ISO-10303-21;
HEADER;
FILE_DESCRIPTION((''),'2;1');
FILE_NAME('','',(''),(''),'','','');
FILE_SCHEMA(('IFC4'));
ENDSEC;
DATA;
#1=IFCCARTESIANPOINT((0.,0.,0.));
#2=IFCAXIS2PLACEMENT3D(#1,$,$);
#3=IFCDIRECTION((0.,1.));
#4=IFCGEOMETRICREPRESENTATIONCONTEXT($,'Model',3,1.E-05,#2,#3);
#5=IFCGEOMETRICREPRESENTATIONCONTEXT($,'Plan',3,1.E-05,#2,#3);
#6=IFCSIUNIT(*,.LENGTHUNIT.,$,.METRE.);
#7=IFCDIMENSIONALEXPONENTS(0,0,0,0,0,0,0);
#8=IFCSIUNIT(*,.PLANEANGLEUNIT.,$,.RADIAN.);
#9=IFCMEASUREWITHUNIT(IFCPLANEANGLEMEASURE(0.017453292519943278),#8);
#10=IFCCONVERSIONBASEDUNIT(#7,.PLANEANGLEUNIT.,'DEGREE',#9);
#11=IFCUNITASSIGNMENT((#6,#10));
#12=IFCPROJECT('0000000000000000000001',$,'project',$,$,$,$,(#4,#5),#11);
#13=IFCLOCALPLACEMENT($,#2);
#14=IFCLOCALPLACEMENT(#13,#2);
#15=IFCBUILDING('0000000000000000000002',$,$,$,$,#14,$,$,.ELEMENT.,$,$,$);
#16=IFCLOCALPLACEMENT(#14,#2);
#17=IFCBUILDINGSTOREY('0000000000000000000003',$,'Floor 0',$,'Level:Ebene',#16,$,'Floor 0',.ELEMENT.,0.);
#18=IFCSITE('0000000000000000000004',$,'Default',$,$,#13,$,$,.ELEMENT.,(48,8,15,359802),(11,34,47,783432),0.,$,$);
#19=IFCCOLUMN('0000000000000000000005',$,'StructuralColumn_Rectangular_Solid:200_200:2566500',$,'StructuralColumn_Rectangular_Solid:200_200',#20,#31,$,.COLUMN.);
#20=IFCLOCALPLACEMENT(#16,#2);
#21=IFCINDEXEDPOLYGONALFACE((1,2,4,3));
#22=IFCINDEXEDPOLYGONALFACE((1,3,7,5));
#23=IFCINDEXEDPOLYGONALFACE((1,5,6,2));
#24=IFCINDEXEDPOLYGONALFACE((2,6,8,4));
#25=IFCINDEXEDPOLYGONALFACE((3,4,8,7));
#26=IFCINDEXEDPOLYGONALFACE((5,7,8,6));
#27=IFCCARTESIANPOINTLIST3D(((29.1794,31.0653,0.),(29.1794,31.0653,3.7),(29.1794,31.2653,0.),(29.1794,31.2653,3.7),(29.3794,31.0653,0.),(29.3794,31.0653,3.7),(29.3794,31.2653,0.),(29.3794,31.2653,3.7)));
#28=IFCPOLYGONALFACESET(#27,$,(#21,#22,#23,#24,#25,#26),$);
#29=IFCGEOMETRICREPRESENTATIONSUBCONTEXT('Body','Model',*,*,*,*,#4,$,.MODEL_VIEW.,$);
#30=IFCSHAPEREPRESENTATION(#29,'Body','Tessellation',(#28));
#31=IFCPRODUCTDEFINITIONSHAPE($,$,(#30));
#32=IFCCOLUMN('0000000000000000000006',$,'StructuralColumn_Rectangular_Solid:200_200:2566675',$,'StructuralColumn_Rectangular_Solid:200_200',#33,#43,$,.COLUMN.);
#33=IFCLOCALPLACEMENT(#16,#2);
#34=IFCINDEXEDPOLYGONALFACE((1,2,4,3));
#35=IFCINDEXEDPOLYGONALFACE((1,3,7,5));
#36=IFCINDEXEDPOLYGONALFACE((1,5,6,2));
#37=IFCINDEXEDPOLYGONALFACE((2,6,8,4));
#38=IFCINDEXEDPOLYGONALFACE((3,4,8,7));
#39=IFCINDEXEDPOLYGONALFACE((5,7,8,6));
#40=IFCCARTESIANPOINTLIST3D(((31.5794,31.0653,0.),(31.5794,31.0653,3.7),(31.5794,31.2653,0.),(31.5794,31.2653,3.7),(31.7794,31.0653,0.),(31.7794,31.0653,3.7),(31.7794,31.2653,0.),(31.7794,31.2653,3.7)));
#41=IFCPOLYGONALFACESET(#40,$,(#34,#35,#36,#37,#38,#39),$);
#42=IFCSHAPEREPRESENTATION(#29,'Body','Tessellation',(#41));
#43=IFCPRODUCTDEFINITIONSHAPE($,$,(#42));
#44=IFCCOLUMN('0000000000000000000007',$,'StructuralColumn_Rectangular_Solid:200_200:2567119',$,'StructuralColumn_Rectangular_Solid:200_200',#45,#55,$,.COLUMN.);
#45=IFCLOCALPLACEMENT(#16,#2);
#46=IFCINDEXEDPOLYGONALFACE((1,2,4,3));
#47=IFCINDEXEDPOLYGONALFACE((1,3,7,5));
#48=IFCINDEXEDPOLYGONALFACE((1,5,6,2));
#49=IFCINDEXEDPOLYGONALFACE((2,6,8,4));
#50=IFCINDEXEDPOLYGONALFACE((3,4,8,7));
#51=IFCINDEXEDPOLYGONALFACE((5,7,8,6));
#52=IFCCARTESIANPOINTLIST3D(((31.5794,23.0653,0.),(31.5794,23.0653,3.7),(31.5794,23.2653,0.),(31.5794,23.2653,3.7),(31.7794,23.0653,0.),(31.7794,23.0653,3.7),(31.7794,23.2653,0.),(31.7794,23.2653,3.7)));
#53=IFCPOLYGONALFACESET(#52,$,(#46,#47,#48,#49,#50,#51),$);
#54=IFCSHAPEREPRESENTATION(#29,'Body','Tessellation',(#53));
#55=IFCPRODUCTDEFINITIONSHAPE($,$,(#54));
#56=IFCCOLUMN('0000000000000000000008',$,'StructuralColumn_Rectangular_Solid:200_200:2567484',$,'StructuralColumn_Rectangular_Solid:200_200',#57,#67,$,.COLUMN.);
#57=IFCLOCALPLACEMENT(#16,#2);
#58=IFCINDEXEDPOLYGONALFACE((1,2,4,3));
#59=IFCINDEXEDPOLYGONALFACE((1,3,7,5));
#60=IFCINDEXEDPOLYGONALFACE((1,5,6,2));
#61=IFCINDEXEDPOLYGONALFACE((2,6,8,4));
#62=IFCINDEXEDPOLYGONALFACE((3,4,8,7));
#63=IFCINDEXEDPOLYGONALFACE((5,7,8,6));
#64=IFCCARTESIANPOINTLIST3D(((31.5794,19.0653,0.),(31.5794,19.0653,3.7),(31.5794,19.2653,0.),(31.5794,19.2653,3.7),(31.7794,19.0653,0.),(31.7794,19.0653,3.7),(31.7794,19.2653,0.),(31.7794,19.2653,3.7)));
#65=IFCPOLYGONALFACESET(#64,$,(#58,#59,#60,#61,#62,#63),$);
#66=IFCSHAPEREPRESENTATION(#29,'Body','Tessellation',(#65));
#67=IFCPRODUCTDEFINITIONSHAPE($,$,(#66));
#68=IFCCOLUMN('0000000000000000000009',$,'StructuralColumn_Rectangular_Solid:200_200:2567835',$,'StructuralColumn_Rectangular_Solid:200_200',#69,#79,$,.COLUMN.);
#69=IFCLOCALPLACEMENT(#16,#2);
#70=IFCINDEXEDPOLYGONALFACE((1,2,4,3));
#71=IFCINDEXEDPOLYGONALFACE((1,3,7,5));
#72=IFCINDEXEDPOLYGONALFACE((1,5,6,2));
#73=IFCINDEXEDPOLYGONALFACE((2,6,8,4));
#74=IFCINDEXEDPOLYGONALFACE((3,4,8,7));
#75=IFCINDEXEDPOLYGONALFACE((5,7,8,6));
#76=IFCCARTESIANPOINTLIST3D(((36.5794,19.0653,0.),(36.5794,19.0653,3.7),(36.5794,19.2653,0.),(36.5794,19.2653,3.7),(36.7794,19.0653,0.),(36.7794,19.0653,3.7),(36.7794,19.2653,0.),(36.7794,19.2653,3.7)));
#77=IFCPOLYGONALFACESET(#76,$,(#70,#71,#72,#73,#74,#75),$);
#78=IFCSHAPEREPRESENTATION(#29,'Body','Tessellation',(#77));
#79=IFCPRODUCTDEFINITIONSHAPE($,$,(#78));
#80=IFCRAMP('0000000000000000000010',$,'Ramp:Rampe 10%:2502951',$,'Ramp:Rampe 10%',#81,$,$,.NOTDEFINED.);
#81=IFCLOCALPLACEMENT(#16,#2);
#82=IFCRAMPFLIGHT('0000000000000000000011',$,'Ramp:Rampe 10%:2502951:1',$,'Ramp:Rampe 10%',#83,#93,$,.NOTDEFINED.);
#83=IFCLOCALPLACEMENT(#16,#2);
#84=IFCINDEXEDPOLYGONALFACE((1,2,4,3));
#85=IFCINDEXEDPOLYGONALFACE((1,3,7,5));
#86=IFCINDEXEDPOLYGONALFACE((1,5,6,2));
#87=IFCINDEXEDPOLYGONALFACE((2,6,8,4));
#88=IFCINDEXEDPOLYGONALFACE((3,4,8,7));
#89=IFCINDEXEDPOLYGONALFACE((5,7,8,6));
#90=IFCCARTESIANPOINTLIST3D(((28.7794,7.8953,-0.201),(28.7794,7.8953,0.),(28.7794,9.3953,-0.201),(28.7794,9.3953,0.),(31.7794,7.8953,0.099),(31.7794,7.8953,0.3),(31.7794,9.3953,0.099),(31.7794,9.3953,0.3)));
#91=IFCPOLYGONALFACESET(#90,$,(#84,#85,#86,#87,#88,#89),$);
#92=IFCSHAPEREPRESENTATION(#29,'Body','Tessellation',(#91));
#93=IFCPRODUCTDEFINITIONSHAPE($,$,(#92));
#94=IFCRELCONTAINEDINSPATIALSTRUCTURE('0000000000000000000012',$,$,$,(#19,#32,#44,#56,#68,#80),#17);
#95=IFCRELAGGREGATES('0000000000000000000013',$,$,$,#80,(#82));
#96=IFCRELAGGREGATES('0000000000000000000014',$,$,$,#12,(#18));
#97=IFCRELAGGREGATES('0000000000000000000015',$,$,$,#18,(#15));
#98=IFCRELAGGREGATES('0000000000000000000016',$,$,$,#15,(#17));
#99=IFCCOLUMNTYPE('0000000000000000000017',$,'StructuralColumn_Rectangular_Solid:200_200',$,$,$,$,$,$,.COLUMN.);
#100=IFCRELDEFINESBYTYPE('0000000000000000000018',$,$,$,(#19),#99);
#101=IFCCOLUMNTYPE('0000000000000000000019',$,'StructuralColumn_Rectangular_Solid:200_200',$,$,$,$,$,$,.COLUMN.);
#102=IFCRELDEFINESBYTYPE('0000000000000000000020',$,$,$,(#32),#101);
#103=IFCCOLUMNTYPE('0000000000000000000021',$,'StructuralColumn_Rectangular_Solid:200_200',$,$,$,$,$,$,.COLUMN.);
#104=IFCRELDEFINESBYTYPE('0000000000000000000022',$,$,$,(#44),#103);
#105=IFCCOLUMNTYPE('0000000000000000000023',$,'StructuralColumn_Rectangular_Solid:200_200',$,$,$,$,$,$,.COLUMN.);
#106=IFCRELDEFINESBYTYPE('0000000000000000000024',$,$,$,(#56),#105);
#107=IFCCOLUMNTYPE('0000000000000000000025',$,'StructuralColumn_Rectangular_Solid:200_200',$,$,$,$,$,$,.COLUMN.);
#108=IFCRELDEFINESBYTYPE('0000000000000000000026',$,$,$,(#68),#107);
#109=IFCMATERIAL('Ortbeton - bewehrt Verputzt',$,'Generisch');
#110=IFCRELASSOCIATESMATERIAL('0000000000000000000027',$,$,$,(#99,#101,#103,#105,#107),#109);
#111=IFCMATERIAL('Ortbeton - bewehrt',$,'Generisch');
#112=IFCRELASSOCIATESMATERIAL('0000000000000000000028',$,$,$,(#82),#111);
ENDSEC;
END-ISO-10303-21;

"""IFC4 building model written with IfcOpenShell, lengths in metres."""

from ifc_helpers import new_model, entity, si_unit, converted_unit, direction, frame, frame_2d, origin, origin_2d_with_axis, place, context, subcontext, project, spatial, polyline, rectangle, outline, extrude, source, transform, mapped, material, material_profile, profile_set, type_object, type_shapes, element, aggregate, save


model = new_model("IFC4")

# Units and contexts
model_context = context("Model", 3, precision=1e-05, world=origin(), true_north=direction((0.0, 1.0)))
plan_context = context("Plan", 3, precision=1e-05, world=origin(), true_north=direction((0.0, 1.0)))
body_context = subcontext(model_context, "Body", "Model", "MODEL_VIEW")
ifc_project = project(units=[si_unit("LENGTHUNIT", "METRE"), converted_unit("PLANEANGLEUNIT", "DEGREE", entity("IfcPlaneAngleMeasure", 0.017453292519943278), si_unit("PLANEANGLEUNIT", "RADIAN"), dimensions=[0, 0, 0, 0, 0, 0, 0])], contexts=[model_context, plan_context])

# Site, building, storey
site_placement = place(None, origin())
site = spatial("IfcSite", under=ifc_project, at=site_placement, Name="Default", CompositionType="ELEMENT", RefLatitude=(48, 8, 15, 359802), RefLongitude=(11, 34, 47, 783432), RefElevation=0.0)
building_placement = place(site_placement, origin())
building = spatial("IfcBuilding", under=site, at=building_placement, CompositionType="ELEMENT")
storey_placement = place(building_placement, origin())
storey = spatial("IfcBuildingStorey", under=building, at=storey_placement, Name="Floor 0", ObjectType="Level:Ebene", LongName="Floor 0", CompositionType="ELEMENT", Elevation=0.0)

# Columns
ifc_material_1 = material(Name="Ortbeton - bewehrt Verputzt", Category="Generisch")
ifc_material_profile = material_profile(ifc_material_1, rectangle(XDim=0.2, YDim=0.2, at=frame_2d((0.0, 0.0), x_axis=(1.0, 0.0))), Name="200_200")
ifc_profile_set = profile_set([ifc_material_profile], Name="200_200")
column_type_1 = type_object("IfcColumnType", Name="StructuralColumn_Rectangular_Solid:200_200", PredefinedType="COLUMN", material=ifc_profile_set)
shared_shape_1 = source(origin(), body_context, "Body", "SweptSolid", [
    extrude(rectangle(XDim=0.2, YDim=0.2, at=origin_2d_with_axis()), frame((29.2794, 31.1653, 0.0), z_axis=(0.0, 0.0, 1.0), x_axis=(-1.0, 0.0, 0.0)), (0.0, 0.0, 1.0), 3.7),
])
type_shapes(column_type_1, [shared_shape_1])
column_1_placement = place(storey_placement, origin())
element("IfcColumn", 1, at=column_1_placement, inside=storey, type_object=column_type_1, Name="StructuralColumn_Rectangular_Solid:200_200:2566500", ObjectType="StructuralColumn_Rectangular_Solid:200_200", PredefinedType="COLUMN", context=body_context, shape_type="MappedRepresentation", body=[
    mapped(shared_shape_1, transform((0.0, 0.0, 0.0), scale=1.0)),
])
column_type_2 = type_object("IfcColumnType", Name="StructuralColumn_Rectangular_Solid:200_200", PredefinedType="COLUMN", material=ifc_profile_set)
shared_shape_2 = source(origin(), body_context, "Body", "SweptSolid", [
    extrude(rectangle(XDim=0.2, YDim=0.2, at=origin_2d_with_axis()), frame((31.6794, 31.1653, 0.0), z_axis=(0.0, 0.0, 1.0), x_axis=(-1.0, 0.0, 0.0)), (0.0, 0.0, 1.0), 3.7),
])
type_shapes(column_type_2, [shared_shape_2])
column_2_placement = place(storey_placement, origin())
element("IfcColumn", 2, at=column_2_placement, inside=storey, type_object=column_type_2, Name="StructuralColumn_Rectangular_Solid:200_200:2566675", ObjectType="StructuralColumn_Rectangular_Solid:200_200", PredefinedType="COLUMN", context=body_context, shape_type="MappedRepresentation", body=[
    mapped(shared_shape_2, transform((0.0, 0.0, 0.0), scale=1.0)),
])
column_type_3 = type_object("IfcColumnType", Name="StructuralColumn_Rectangular_Solid:200_200", PredefinedType="COLUMN", material=ifc_profile_set)
shared_shape_3 = source(origin(), body_context, "Body", "SweptSolid", [
    extrude(rectangle(XDim=0.2, YDim=0.2, at=origin_2d_with_axis()), frame((31.6794, 23.1653, 0.0), z_axis=(0.0, 0.0, 1.0), x_axis=(-1.0, 0.0, 0.0)), (0.0, 0.0, 1.0), 3.7),
])
type_shapes(column_type_3, [shared_shape_3])
column_3_placement = place(storey_placement, origin())
element("IfcColumn", 3, at=column_3_placement, inside=storey, type_object=column_type_3, Name="StructuralColumn_Rectangular_Solid:200_200:2567119", ObjectType="StructuralColumn_Rectangular_Solid:200_200", PredefinedType="COLUMN", context=body_context, shape_type="MappedRepresentation", body=[
    mapped(shared_shape_3, transform((0.0, 0.0, 0.0), scale=1.0)),
])
column_type_4 = type_object("IfcColumnType", Name="StructuralColumn_Rectangular_Solid:200_200", PredefinedType="COLUMN", material=ifc_profile_set)
shared_shape_4 = source(origin(), body_context, "Body", "SweptSolid", [
    extrude(rectangle(XDim=0.2, YDim=0.2, at=frame_2d((0.0, 0.0), x_axis=(1.0, 0.0))), frame((31.6794, 19.1653, 0.0), z_axis=(0.0, 0.0, 1.0), x_axis=(-1.0, 0.0, 0.0)), (0.0, 0.0, 1.0), 3.7),
])
type_shapes(column_type_4, [shared_shape_4])
column_4_placement = place(storey_placement, origin())
element("IfcColumn", 4, at=column_4_placement, inside=storey, type_object=column_type_4, Name="StructuralColumn_Rectangular_Solid:200_200:2567484", ObjectType="StructuralColumn_Rectangular_Solid:200_200", PredefinedType="COLUMN", context=body_context, shape_type="MappedRepresentation", body=[
    mapped(shared_shape_4, transform((0.0, 0.0, 0.0), scale=1.0)),
])
column_type_5 = type_object("IfcColumnType", Name="StructuralColumn_Rectangular_Solid:200_200", PredefinedType="COLUMN", material=ifc_profile_set)
shared_shape_5 = source(origin(), body_context, "Body", "SweptSolid", [
    extrude(rectangle(XDim=0.2, YDim=0.2, at=frame_2d((0.0, 0.0), x_axis=(1.0, 0.0))), frame((36.6794, 19.1653, 0.0), z_axis=(0.0, 0.0, 1.0), x_axis=(-1.0, 0.0, 0.0)), (0.0, 0.0, 1.0), 3.7),
])
type_shapes(column_type_5, [shared_shape_5])
column_5_placement = place(storey_placement, origin())
element("IfcColumn", 5, at=column_5_placement, inside=storey, type_object=column_type_5, Name="StructuralColumn_Rectangular_Solid:200_200:2567835", ObjectType="StructuralColumn_Rectangular_Solid:200_200", PredefinedType="COLUMN", context=body_context, shape_type="MappedRepresentation", body=[
    mapped(shared_shape_5, transform((0.0, 0.0, 0.0), scale=1.0)),
])

# Ramp, ramp flight
ramp_placement = place(storey_placement, origin())
ramp = element("IfcRamp", 6, at=ramp_placement, inside=storey, Name="Ramp:Rampe 10%:2502951", ObjectType="Ramp:Rampe 10%", PredefinedType="NOTDEFINED")
ifc_material_2 = material(Name="Ortbeton - bewehrt", Category="Generisch")
ramp_flight_placement = place(ramp_placement, origin())
ramp_flight = element("IfcRampFlight", 7, at=ramp_flight_placement, material=ifc_material_2, Name="Ramp:Rampe 10%:2502951:1", ObjectType="Ramp:Rampe 10%", PredefinedType="NOTDEFINED", context=body_context, shape_type="SweptSolid", body=[
    extrude(outline(polyline([(-0.2505, -1.5), (-0.0495, -1.5), (0.2505, 1.5), (0.0495, 1.5), (-0.2505, -1.5)])), frame((30.2794, 7.8953, 0.0495), z_axis=(0.0, 1.0, 0.0), x_axis=(0.0, 0.0, -1.0)), (0.0, 0.0, 1.0), 1.5),
])
aggregate(ramp, [ramp_flight])

save(model, "model.ifc")
